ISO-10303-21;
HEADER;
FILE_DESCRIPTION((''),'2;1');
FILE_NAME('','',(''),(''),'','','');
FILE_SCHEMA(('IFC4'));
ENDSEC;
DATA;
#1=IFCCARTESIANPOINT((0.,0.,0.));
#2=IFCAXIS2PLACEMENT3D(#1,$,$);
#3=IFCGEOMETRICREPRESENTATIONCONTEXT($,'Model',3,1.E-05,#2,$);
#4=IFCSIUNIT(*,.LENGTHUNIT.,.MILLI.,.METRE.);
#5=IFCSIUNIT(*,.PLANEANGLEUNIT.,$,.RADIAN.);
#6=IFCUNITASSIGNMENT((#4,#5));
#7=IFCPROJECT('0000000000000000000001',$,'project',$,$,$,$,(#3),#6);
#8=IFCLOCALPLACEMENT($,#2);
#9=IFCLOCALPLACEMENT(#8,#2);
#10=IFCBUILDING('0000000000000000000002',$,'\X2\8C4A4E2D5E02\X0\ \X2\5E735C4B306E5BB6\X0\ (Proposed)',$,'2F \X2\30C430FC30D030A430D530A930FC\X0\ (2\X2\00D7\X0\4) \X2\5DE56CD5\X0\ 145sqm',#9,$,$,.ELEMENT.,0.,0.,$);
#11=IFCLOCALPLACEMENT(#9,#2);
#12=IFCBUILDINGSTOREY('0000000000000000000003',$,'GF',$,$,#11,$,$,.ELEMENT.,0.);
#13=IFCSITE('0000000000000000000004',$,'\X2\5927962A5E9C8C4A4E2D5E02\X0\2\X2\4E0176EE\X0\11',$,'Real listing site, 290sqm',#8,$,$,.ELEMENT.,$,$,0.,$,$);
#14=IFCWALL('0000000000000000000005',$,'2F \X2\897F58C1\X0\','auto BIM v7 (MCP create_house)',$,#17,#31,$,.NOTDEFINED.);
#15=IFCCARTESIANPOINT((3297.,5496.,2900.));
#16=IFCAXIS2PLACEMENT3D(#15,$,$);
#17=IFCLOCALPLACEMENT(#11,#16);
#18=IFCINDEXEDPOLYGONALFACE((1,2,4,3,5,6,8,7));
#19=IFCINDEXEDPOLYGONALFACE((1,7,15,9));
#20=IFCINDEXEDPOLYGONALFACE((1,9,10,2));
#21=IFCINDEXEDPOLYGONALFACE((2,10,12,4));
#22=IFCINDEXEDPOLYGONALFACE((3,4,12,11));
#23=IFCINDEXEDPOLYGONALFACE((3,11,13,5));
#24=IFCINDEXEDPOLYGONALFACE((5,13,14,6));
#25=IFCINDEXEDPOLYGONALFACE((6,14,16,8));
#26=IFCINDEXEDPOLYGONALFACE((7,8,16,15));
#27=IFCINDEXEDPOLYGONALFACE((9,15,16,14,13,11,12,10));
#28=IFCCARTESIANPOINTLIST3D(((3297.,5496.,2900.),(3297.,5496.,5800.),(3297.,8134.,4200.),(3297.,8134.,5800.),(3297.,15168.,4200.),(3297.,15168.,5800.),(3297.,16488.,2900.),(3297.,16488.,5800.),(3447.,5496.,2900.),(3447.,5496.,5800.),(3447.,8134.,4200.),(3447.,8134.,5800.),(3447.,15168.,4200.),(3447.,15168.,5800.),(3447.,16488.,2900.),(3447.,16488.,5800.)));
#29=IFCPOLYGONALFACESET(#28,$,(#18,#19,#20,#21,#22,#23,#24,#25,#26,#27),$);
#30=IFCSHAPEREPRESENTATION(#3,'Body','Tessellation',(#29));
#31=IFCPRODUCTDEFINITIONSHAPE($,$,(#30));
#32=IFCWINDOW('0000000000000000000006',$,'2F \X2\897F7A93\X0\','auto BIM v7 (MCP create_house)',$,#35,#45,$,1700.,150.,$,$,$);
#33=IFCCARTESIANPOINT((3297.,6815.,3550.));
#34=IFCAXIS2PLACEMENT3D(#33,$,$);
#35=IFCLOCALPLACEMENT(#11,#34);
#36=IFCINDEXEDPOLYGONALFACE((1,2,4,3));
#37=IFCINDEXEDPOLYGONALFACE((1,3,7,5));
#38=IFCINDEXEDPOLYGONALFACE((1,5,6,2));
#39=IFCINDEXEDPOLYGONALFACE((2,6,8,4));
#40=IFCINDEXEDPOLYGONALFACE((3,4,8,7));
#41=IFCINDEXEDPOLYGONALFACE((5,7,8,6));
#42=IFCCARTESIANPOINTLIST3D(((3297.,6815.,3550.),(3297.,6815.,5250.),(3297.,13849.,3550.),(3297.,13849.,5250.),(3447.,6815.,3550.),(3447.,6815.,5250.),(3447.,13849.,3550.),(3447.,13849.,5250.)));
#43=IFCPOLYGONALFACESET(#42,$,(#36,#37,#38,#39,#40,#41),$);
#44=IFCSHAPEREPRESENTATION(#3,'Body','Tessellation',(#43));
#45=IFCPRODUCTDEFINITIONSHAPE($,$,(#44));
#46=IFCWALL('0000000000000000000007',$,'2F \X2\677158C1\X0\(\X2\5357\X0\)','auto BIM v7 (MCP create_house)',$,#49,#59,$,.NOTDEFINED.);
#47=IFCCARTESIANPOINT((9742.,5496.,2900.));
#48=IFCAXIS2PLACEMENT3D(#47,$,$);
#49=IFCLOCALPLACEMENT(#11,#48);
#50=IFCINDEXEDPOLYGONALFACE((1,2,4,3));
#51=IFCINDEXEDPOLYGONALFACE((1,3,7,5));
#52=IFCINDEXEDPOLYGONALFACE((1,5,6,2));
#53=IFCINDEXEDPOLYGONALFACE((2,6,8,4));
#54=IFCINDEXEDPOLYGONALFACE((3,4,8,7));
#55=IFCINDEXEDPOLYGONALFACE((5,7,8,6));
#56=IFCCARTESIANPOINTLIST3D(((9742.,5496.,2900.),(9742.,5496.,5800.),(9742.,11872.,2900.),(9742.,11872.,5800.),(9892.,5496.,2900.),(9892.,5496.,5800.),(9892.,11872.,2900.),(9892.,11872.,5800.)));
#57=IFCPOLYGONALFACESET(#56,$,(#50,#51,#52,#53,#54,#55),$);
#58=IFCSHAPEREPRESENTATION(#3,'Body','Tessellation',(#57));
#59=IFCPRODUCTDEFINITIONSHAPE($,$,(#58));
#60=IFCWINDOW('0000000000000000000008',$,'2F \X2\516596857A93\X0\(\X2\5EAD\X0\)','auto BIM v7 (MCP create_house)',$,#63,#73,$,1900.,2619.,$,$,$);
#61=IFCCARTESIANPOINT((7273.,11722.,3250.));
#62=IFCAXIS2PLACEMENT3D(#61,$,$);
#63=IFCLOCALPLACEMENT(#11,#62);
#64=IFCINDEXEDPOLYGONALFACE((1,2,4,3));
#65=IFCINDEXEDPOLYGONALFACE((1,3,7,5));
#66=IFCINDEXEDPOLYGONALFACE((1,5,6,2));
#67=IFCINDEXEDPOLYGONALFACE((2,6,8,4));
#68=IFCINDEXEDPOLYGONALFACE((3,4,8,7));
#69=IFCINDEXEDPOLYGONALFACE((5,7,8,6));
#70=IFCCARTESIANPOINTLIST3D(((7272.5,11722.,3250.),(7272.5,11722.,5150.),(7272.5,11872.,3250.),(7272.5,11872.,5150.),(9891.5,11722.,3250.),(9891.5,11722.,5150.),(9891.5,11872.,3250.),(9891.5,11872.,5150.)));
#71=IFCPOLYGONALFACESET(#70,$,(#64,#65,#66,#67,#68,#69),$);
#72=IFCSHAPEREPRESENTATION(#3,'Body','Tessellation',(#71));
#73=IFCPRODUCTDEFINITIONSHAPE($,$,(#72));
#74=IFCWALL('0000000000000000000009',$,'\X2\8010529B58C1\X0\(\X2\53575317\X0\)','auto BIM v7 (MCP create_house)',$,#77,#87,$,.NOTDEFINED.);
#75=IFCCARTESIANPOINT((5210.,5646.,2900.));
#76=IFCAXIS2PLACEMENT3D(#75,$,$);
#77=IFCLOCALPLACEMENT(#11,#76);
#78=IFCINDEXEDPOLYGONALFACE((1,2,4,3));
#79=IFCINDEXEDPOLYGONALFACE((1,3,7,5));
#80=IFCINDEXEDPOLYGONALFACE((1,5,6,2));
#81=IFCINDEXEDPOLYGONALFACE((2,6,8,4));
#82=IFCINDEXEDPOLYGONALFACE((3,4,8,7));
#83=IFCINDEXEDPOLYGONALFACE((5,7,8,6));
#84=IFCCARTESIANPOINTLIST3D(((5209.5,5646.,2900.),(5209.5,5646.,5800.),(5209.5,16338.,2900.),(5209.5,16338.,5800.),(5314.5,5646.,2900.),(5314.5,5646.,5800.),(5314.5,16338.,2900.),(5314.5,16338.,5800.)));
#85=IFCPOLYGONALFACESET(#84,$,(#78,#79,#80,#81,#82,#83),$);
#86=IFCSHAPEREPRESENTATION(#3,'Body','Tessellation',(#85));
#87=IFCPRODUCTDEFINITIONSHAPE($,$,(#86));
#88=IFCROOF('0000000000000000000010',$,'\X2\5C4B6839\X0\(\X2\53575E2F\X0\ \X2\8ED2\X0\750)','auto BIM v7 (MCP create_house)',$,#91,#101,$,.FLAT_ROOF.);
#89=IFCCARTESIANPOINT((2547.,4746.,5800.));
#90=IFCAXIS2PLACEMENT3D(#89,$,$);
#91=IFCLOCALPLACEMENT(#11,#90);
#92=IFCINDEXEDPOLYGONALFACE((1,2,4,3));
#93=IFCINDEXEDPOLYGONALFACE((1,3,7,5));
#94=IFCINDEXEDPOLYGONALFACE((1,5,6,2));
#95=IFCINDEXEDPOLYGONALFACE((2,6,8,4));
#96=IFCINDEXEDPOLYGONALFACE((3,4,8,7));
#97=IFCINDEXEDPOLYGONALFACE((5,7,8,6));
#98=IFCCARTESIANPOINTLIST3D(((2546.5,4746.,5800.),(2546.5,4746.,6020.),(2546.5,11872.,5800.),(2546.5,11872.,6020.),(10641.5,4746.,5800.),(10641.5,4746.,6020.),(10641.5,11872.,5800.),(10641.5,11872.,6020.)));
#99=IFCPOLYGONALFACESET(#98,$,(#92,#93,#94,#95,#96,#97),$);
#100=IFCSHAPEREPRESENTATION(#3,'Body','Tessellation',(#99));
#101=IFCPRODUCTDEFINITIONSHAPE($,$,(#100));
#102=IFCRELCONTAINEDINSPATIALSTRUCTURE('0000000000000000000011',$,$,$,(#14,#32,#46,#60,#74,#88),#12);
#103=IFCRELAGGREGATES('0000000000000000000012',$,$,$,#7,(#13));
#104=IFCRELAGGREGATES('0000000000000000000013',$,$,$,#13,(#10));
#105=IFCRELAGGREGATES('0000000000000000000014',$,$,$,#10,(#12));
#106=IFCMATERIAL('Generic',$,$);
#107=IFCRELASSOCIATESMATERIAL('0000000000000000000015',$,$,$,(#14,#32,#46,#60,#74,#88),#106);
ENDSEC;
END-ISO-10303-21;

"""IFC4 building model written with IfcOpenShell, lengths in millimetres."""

from ifc_helpers import new_model, si_unit, frame, frame_2d, origin, place, context, project, spatial, rectangle, extrude, material, element, fill, save


model = new_model("IFC4")

# Units and contexts
model_context = context("Model", 3, precision=1e-05, world=origin())
ifc_project = project(units=[si_unit("LENGTHUNIT", "METRE", prefix="MILLI"), si_unit("PLANEANGLEUNIT", "RADIAN")], contexts=[model_context])

# Site, building, storey
site_placement = place(None, origin())
site = spatial("IfcSite", under=ifc_project, at=site_placement, Name="大阪府豊中市2丁目11", ObjectType="Real listing site, 290sqm", CompositionType="ELEMENT", RefElevation=0.0)
building_placement = place(site_placement, origin())
building = spatial("IfcBuilding", under=site, at=building_placement, Name="豊中市 平屋の家 (Proposed)", ObjectType="2F ツーバイフォー (2×4) 工法 145sqm", CompositionType="ELEMENT", ElevationOfRefHeight=0.0, ElevationOfTerrain=0.0)
storey_placement = place(building_placement, origin())
storey = spatial("IfcBuildingStorey", under=building, at=storey_placement, Name="GF", CompositionType="ELEMENT", Elevation=0.0)

# Shared definitions
ifc_material = material(Name="Generic")

# Walls, openings, windows
wall_1_placement = place(storey_placement, frame((3297.0, 5496.0, 2900.0)))
wall_1 = element("IfcWall", 1, at=wall_1_placement, inside=storey, material=ifc_material, Name="2F 西壁", Description="auto BIM v7 (MCP create_house)", PredefinedType="NOTDEFINED", context=model_context, shape_type="SweptSolid", body=[
    extrude(rectangle(XDim=150.0, YDim=10992.0, at=frame_2d((75.0, 5496.0))), frame((3297.0, 5496.0, 2900.0)), (0.0, 0.0, 1.0), 2900.0),
])
opening_1_placement = place(storey_placement, frame((3297.0, 6815.0, 3550.0)))
opening_1 = element("IfcOpeningElement", 2, at=opening_1_placement, cuts=wall_1, PredefinedType="NOTDEFINED", context=model_context, shape_type="SweptSolid", body=[
    extrude(rectangle(XDim=150.0, YDim=7034.0, at=frame_2d((75.0, 3517.0))), frame((3297.0, 6815.0, 3550.0)), (0.0, 0.0, 1.0), 1700.0),
])
window_1_placement = place(storey_placement, frame((3297.0, 6815.0, 3550.0)))
window_1 = element("IfcWindow", 3, at=window_1_placement, inside=storey, material=ifc_material, Name="2F 西窓", Description="auto BIM v7 (MCP create_house)", OverallHeight=1700.0, OverallWidth=150.0, context=model_context, shape_type="SweptSolid", body=[
    extrude(rectangle(XDim=150.0, YDim=7034.0, at=frame_2d((75.0, 3517.0))), frame((3297.0, 6815.0, 3550.0)), (0.0, 0.0, 1.0), 1700.0),
])
fill(opening_1, window_1)
wall_2_placement = place(storey_placement, frame((9742.0, 5496.0, 2900.0)))
wall_2 = element("IfcWall", 4, at=wall_2_placement, inside=storey, material=ifc_material, Name="2F 東壁(南)", Description="auto BIM v7 (MCP create_house)", PredefinedType="NOTDEFINED", context=model_context, shape_type="SweptSolid", body=[
    extrude(rectangle(XDim=150.0, YDim=6376.0, at=frame_2d((75.0, 3188.0))), frame((9742.0, 5496.0, 2900.0)), (0.0, 0.0, 1.0), 2900.0),
])
opening_2_placement = place(storey_placement, frame((7273.0, 11722.0, 3250.0)))
opening_2 = element("IfcOpeningElement", 5, at=opening_2_placement, cuts=wall_2, PredefinedType="NOTDEFINED", context=model_context, shape_type="SweptSolid", body=[
    extrude(rectangle(XDim=2619.0, YDim=150.0, at=frame_2d((1309.0, 75.0))), frame((7273.0, 11722.0, 3250.0)), (0.0, 0.0, 1.0), 1900.0),
])
window_2_placement = place(storey_placement, frame((7273.0, 11722.0, 3250.0)))
window_2 = element("IfcWindow", 6, at=window_2_placement, inside=storey, material=ifc_material, Name="2F 入隅窓(庭)", Description="auto BIM v7 (MCP create_house)", OverallHeight=1900.0, OverallWidth=2619.0, context=model_context, shape_type="SweptSolid", body=[
    extrude(rectangle(XDim=2619.0, YDim=150.0, at=frame_2d((1309.0, 75.0))), frame((7273.0, 11722.0, 3250.0)), (0.0, 0.0, 1.0), 1900.0),
])
fill(opening_2, window_2)

# Wall
wall_3_placement = place(storey_placement, frame((5210.0, 5646.0, 2900.0)))
element("IfcWall", 7, at=wall_3_placement, inside=storey, material=ifc_material, Name="耐力壁(南北)", Description="auto BIM v7 (MCP create_house)", PredefinedType="NOTDEFINED", context=model_context, shape_type="SweptSolid", body=[
    extrude(rectangle(XDim=105.0, YDim=10692.0, at=frame_2d((52.0, 5346.0))), frame((5210.0, 5646.0, 2900.0)), (0.0, 0.0, 1.0), 2900.0),
])

# Roof
for number, where, name in (
    (8, (2547.0, 4746.0, 5800.0), "屋根(南帯 軒750)"),
):
    element("IfcRoof", number, at=place(storey_placement, frame(where)), inside=storey, material=ifc_material, Name=name, Description="auto BIM v7 (MCP create_house)", PredefinedType="FLAT_ROOF", context=model_context, shape_type="SweptSolid", body=[
        extrude(rectangle(XDim=8095.0, YDim=7126.0, at=frame_2d((4047.0, 3563.0))), frame((2547.0, 4746.0, 5800.0)), (0.0, 0.0, 1.0), 220.0),
    ])

save(model, "model.ifc")
